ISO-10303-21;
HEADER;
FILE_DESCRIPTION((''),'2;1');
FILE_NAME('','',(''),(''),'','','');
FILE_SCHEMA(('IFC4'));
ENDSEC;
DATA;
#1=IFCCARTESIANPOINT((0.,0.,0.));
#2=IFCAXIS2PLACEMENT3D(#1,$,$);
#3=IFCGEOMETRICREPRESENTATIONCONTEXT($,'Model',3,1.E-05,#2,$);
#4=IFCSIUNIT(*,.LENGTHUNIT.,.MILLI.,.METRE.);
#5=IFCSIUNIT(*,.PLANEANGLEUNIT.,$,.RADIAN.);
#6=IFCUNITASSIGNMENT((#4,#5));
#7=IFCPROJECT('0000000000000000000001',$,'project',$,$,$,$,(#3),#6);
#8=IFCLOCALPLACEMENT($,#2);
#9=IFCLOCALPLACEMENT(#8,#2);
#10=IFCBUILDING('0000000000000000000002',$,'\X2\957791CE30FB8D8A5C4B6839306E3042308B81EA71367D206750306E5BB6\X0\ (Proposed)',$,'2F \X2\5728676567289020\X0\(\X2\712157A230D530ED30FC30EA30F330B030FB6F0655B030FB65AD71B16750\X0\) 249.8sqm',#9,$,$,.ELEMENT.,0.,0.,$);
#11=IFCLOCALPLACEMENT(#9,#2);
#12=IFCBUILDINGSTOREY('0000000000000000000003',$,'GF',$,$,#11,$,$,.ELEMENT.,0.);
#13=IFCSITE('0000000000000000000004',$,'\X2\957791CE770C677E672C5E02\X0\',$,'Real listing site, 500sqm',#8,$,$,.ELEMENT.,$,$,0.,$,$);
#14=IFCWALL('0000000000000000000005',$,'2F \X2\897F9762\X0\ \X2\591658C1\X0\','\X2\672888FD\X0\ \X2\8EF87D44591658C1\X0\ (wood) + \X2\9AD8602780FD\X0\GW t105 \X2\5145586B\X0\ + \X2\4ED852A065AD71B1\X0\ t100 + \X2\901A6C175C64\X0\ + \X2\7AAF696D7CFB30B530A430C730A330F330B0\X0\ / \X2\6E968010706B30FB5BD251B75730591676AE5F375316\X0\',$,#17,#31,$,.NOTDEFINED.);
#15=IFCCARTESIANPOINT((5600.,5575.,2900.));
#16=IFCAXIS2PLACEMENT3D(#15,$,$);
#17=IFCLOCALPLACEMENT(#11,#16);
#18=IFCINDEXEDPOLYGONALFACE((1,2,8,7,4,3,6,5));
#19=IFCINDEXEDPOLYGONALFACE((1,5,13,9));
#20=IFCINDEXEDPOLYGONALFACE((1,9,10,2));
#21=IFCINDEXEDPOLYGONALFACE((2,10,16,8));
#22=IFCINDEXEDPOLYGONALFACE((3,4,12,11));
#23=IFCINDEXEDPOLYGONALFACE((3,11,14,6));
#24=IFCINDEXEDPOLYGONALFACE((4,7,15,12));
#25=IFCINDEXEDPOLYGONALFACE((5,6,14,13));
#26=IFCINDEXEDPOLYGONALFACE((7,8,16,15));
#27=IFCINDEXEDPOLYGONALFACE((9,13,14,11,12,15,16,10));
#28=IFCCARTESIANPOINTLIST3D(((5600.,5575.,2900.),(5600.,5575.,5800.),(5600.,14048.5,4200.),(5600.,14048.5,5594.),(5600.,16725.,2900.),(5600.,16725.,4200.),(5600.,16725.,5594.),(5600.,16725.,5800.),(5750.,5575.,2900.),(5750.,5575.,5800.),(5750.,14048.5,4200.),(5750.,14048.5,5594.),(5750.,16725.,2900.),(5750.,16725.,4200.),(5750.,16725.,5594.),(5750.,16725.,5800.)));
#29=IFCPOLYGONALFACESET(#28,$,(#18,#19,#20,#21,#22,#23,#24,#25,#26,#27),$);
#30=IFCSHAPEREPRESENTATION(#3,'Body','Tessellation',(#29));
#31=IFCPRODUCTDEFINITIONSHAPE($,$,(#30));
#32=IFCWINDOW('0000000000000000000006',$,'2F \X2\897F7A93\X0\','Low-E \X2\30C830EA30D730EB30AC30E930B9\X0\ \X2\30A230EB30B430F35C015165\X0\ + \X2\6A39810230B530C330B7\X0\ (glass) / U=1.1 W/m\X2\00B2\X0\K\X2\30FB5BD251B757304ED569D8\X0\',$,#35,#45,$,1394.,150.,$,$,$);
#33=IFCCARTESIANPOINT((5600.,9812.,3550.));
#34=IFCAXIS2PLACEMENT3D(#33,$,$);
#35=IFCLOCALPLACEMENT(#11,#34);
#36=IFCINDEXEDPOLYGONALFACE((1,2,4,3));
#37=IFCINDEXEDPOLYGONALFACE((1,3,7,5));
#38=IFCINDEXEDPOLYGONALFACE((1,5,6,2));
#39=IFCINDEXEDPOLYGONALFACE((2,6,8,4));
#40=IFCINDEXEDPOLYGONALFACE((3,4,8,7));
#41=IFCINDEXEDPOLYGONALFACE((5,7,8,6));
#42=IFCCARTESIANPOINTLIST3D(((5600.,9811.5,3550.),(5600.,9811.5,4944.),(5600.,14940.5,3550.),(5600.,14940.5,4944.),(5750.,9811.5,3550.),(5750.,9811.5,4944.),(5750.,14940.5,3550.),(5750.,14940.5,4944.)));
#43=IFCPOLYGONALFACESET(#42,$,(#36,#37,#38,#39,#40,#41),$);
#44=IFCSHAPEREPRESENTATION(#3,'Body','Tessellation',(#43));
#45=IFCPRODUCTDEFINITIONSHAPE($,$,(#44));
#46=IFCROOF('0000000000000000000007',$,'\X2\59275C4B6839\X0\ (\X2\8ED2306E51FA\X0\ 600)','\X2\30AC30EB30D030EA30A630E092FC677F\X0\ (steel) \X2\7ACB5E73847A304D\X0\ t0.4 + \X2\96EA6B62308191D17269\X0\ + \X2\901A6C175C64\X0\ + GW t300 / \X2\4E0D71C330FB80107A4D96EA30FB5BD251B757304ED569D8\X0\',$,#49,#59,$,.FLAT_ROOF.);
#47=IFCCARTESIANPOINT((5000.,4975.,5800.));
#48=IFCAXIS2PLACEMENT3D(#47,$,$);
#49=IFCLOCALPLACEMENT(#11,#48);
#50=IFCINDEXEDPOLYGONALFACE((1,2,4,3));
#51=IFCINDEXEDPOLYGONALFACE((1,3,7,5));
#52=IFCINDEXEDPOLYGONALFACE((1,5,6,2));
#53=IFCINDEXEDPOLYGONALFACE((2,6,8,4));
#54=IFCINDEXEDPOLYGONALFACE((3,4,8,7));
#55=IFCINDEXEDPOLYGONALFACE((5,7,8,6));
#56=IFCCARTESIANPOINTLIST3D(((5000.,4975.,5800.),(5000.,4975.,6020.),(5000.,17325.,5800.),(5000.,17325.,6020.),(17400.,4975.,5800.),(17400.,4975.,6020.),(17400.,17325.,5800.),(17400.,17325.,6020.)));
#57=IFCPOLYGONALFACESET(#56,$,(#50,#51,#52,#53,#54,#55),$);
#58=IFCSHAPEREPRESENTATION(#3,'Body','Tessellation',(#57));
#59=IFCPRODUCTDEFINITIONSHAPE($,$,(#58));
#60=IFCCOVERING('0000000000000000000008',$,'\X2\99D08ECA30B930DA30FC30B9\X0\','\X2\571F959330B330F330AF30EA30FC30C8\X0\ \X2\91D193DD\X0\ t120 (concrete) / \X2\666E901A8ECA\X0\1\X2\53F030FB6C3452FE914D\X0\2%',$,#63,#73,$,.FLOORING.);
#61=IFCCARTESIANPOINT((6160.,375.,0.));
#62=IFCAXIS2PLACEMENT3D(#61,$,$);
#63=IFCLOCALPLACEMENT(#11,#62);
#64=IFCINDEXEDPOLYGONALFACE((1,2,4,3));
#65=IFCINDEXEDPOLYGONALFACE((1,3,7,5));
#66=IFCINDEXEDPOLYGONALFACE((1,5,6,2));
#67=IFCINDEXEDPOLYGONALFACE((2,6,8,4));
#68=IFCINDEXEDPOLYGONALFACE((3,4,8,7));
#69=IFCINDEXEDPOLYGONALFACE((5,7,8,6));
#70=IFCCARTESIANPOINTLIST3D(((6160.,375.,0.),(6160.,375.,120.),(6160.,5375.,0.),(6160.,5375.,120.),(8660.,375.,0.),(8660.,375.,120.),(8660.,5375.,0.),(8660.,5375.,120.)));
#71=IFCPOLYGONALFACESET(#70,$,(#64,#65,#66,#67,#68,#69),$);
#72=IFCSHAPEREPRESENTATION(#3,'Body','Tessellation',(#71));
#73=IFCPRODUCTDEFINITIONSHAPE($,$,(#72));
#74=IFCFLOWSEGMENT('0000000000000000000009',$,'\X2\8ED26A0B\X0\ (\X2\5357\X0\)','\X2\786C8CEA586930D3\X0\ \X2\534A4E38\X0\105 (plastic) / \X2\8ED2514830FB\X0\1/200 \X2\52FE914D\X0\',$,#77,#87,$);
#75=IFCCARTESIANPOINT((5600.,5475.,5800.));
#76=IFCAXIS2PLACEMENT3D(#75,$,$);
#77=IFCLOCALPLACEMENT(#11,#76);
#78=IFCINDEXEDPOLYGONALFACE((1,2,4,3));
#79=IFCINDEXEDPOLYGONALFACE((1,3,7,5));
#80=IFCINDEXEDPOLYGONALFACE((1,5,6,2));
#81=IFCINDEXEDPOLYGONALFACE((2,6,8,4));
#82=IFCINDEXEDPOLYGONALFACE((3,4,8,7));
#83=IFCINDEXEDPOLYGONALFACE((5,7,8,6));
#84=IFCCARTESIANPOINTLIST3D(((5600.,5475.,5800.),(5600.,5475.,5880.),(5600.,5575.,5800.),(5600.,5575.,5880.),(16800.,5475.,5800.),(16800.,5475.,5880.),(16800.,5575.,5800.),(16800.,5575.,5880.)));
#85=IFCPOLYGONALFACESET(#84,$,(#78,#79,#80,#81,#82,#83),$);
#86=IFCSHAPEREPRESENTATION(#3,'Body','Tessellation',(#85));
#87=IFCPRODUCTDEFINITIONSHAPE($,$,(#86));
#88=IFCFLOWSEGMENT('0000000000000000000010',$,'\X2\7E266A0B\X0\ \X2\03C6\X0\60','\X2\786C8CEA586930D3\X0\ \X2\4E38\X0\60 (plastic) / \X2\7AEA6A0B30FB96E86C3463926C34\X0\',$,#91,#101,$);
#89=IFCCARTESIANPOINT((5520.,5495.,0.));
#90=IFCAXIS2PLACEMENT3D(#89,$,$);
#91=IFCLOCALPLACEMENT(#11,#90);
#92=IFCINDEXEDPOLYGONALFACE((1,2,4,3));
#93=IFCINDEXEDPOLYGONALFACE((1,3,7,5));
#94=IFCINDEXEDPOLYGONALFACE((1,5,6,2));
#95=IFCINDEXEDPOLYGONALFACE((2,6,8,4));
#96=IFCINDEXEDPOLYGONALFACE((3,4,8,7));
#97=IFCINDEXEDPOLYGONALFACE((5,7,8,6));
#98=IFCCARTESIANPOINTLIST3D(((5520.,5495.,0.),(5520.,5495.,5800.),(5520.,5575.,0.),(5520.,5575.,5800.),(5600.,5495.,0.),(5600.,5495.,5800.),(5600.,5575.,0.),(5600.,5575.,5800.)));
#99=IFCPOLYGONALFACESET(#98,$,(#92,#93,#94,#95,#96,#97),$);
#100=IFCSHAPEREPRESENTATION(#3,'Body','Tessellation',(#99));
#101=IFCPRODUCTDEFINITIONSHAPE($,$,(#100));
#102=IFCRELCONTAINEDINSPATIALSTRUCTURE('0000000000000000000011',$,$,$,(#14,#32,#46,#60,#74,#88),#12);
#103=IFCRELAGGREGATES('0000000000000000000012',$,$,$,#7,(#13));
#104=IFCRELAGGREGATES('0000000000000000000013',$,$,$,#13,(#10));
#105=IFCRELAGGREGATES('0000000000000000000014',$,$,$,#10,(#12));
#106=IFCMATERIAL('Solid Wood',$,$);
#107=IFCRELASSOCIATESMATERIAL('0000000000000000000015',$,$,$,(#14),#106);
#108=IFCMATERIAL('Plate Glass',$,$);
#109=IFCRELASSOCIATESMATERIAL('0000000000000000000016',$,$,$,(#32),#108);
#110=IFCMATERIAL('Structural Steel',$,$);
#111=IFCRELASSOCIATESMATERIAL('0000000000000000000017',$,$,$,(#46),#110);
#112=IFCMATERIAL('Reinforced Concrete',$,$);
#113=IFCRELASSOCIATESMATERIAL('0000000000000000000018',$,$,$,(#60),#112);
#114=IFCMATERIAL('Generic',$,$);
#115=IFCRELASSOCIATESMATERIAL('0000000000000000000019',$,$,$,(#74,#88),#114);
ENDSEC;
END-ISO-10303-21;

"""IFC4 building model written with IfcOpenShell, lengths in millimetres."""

from ifc_helpers import new_model, si_unit, frame, frame_2d, origin, place, context, project, spatial, rectangle, extrude, material, element, fill, save


model = new_model("IFC4")

# Units and contexts
model_context = context("Model", 3, precision=1e-05, world=origin())
ifc_project = project(units=[si_unit("LENGTHUNIT", "METRE", prefix="MILLI"), si_unit("PLANEANGLEUNIT", "RADIAN")], contexts=[model_context])

# Site, building, storey
site_placement = place(None, origin())
site = spatial("IfcSite", under=ifc_project, at=site_placement, Name="長野県松本市", ObjectType="Real listing site, 500sqm", CompositionType="ELEMENT", RefElevation=0.0)
building_placement = place(site_placement, origin())
building = spatial("IfcBuilding", under=site, at=building_placement, Name="長野・越屋根のある自然素材の家 (Proposed)", ObjectType="2F 在来木造(無垢フローリング・漆喰・断熱材) 249.8sqm", CompositionType="ELEMENT", ElevationOfRefHeight=0.0, ElevationOfTerrain=0.0)
storey_placement = place(building_placement, origin())
storey = spatial("IfcBuildingStorey", under=building, at=storey_placement, Name="GF", CompositionType="ELEMENT", Elevation=0.0)

# Shared definitions
ifc_material_1 = material(Name="Solid Wood")

# Shared definitions
ifc_material_2 = material(Name="Reinforced Concrete")

# Shared definitions
ifc_material_3 = material(Name="Plate Glass")

# Wall, opening, window
wall_1_placement = place(storey_placement, frame((5600.0, 5575.0, 2900.0)))
wall_1 = element("IfcWall", 1, at=wall_1_placement, inside=storey, material=ifc_material_1, Name="2F 西面 外壁", Description="木製 軸組外壁 (wood) + 高性能GW t105 充填 + 付加断熱 t100 + 通気層 + 窯業系サイディング / 準耐火・寒冷地外皮強化", PredefinedType="NOTDEFINED", context=model_context, shape_type="SweptSolid", body=[
    extrude(rectangle(XDim=150.0, YDim=11150.0, at=frame_2d((75.0, 5575.0))), frame((5600.0, 5575.0, 2900.0)), (0.0, 0.0, 1.0), 2900.0),
])
opening_1_placement = place(storey_placement, frame((5600.0, 9812.0, 3550.0)))
opening_1 = element("IfcOpeningElement", 2, at=opening_1_placement, cuts=wall_1, PredefinedType="NOTDEFINED", context=model_context, shape_type="SweptSolid", body=[
    extrude(rectangle(XDim=150.0, YDim=5129.0, at=frame_2d((75.0, 2564.0))), frame((5600.0, 9812.0, 3550.0)), (0.0, 0.0, 1.0), 1394.0),
])
window_1_placement = place(storey_placement, frame((5600.0, 9812.0, 3550.0)))
window_1 = element("IfcWindow", 3, at=window_1_placement, inside=storey, material=ifc_material_3, Name="2F 西窓", Description="Low-E トリプルガラス アルゴン封入 + 樹脂サッシ (glass) / U=1.1 W/m²K・寒冷地仕様", OverallHeight=1394.0, OverallWidth=150.0, context=model_context, shape_type="SweptSolid", body=[
    extrude(rectangle(XDim=150.0, YDim=5129.0, at=frame_2d((75.0, 2564.0))), frame((5600.0, 9812.0, 3550.0)), (0.0, 0.0, 1.0), 1394.0),
])
fill(opening_1, window_1)

# Roof
ifc_material_4 = material(Name="Structural Steel")
roof_placement = place(storey_placement, frame((5000.0, 4975.0, 5800.0)))
element("IfcRoof", 4, at=roof_placement, inside=storey, material=ifc_material_4, Name="大屋根 (軒の出 600)", Description="ガルバリウム鋼板 (steel) 立平葺き t0.4 + 雪止め金物 + 通気層 + GW t300 / 不燃・耐積雪・寒冷地仕様", PredefinedType="FLAT_ROOF", context=model_context, shape_type="SweptSolid", body=[
    extrude(rectangle(XDim=12400.0, YDim=12350.0, at=frame_2d((6200.0, 6175.0))), frame((5000.0, 4975.0, 5800.0)), (0.0, 0.0, 1.0), 220.0),
])

# Covering
covering_placement = place(storey_placement, frame((6160.0, 375.0, 0.0)))
element("IfcCovering", 5, at=covering_placement, inside=storey, material=ifc_material_2, Name="駐車スペース", Description="土間コンクリート 金鏝 t120 (concrete) / 普通車1台・水勾配2%", PredefinedType="FLOORING", context=model_context, shape_type="SweptSolid", body=[
    extrude(rectangle(XDim=2500.0, YDim=5000.0, at=frame_2d((1250.0, 2500.0))), frame((6160.0, 375.0, 0.0)), (0.0, 0.0, 1.0), 120.0),
])

# Flow segments
ifc_material_5 = material(Name="Generic")
flow_segment_1_placement = place(storey_placement, frame((5600.0, 5475.0, 5800.0)))
element("IfcFlowSegment", 6, at=flow_segment_1_placement, inside=storey, material=ifc_material_5, Name="軒樋 (南)", Description="硬質塩ビ 半丸105 (plastic) / 軒先・1/200 勾配", context=model_context, shape_type="SweptSolid", body=[
    extrude(rectangle(XDim=11200.0, YDim=100.0, at=frame_2d((5600.0, 50.0))), frame((5600.0, 5475.0, 5800.0)), (0.0, 0.0, 1.0), 80.0),
])
flow_segment_2_placement = place(storey_placement, frame((5520.0, 5495.0, 0.0)))
element("IfcFlowSegment", 7, at=flow_segment_2_placement, inside=storey, material=ifc_material_5, Name="縦樋 φ60", Description="硬質塩ビ 丸60 (plastic) / 竪樋・雨水排水", context=model_context, shape_type="SweptSolid", body=[
    extrude(rectangle(XDim=80.0, YDim=80.0, at=frame_2d((40.0, 40.0))), frame((5520.0, 5495.0, 0.0)), (0.0, 0.0, 1.0), 5800.0),
])

save(model, "model.ifc")
